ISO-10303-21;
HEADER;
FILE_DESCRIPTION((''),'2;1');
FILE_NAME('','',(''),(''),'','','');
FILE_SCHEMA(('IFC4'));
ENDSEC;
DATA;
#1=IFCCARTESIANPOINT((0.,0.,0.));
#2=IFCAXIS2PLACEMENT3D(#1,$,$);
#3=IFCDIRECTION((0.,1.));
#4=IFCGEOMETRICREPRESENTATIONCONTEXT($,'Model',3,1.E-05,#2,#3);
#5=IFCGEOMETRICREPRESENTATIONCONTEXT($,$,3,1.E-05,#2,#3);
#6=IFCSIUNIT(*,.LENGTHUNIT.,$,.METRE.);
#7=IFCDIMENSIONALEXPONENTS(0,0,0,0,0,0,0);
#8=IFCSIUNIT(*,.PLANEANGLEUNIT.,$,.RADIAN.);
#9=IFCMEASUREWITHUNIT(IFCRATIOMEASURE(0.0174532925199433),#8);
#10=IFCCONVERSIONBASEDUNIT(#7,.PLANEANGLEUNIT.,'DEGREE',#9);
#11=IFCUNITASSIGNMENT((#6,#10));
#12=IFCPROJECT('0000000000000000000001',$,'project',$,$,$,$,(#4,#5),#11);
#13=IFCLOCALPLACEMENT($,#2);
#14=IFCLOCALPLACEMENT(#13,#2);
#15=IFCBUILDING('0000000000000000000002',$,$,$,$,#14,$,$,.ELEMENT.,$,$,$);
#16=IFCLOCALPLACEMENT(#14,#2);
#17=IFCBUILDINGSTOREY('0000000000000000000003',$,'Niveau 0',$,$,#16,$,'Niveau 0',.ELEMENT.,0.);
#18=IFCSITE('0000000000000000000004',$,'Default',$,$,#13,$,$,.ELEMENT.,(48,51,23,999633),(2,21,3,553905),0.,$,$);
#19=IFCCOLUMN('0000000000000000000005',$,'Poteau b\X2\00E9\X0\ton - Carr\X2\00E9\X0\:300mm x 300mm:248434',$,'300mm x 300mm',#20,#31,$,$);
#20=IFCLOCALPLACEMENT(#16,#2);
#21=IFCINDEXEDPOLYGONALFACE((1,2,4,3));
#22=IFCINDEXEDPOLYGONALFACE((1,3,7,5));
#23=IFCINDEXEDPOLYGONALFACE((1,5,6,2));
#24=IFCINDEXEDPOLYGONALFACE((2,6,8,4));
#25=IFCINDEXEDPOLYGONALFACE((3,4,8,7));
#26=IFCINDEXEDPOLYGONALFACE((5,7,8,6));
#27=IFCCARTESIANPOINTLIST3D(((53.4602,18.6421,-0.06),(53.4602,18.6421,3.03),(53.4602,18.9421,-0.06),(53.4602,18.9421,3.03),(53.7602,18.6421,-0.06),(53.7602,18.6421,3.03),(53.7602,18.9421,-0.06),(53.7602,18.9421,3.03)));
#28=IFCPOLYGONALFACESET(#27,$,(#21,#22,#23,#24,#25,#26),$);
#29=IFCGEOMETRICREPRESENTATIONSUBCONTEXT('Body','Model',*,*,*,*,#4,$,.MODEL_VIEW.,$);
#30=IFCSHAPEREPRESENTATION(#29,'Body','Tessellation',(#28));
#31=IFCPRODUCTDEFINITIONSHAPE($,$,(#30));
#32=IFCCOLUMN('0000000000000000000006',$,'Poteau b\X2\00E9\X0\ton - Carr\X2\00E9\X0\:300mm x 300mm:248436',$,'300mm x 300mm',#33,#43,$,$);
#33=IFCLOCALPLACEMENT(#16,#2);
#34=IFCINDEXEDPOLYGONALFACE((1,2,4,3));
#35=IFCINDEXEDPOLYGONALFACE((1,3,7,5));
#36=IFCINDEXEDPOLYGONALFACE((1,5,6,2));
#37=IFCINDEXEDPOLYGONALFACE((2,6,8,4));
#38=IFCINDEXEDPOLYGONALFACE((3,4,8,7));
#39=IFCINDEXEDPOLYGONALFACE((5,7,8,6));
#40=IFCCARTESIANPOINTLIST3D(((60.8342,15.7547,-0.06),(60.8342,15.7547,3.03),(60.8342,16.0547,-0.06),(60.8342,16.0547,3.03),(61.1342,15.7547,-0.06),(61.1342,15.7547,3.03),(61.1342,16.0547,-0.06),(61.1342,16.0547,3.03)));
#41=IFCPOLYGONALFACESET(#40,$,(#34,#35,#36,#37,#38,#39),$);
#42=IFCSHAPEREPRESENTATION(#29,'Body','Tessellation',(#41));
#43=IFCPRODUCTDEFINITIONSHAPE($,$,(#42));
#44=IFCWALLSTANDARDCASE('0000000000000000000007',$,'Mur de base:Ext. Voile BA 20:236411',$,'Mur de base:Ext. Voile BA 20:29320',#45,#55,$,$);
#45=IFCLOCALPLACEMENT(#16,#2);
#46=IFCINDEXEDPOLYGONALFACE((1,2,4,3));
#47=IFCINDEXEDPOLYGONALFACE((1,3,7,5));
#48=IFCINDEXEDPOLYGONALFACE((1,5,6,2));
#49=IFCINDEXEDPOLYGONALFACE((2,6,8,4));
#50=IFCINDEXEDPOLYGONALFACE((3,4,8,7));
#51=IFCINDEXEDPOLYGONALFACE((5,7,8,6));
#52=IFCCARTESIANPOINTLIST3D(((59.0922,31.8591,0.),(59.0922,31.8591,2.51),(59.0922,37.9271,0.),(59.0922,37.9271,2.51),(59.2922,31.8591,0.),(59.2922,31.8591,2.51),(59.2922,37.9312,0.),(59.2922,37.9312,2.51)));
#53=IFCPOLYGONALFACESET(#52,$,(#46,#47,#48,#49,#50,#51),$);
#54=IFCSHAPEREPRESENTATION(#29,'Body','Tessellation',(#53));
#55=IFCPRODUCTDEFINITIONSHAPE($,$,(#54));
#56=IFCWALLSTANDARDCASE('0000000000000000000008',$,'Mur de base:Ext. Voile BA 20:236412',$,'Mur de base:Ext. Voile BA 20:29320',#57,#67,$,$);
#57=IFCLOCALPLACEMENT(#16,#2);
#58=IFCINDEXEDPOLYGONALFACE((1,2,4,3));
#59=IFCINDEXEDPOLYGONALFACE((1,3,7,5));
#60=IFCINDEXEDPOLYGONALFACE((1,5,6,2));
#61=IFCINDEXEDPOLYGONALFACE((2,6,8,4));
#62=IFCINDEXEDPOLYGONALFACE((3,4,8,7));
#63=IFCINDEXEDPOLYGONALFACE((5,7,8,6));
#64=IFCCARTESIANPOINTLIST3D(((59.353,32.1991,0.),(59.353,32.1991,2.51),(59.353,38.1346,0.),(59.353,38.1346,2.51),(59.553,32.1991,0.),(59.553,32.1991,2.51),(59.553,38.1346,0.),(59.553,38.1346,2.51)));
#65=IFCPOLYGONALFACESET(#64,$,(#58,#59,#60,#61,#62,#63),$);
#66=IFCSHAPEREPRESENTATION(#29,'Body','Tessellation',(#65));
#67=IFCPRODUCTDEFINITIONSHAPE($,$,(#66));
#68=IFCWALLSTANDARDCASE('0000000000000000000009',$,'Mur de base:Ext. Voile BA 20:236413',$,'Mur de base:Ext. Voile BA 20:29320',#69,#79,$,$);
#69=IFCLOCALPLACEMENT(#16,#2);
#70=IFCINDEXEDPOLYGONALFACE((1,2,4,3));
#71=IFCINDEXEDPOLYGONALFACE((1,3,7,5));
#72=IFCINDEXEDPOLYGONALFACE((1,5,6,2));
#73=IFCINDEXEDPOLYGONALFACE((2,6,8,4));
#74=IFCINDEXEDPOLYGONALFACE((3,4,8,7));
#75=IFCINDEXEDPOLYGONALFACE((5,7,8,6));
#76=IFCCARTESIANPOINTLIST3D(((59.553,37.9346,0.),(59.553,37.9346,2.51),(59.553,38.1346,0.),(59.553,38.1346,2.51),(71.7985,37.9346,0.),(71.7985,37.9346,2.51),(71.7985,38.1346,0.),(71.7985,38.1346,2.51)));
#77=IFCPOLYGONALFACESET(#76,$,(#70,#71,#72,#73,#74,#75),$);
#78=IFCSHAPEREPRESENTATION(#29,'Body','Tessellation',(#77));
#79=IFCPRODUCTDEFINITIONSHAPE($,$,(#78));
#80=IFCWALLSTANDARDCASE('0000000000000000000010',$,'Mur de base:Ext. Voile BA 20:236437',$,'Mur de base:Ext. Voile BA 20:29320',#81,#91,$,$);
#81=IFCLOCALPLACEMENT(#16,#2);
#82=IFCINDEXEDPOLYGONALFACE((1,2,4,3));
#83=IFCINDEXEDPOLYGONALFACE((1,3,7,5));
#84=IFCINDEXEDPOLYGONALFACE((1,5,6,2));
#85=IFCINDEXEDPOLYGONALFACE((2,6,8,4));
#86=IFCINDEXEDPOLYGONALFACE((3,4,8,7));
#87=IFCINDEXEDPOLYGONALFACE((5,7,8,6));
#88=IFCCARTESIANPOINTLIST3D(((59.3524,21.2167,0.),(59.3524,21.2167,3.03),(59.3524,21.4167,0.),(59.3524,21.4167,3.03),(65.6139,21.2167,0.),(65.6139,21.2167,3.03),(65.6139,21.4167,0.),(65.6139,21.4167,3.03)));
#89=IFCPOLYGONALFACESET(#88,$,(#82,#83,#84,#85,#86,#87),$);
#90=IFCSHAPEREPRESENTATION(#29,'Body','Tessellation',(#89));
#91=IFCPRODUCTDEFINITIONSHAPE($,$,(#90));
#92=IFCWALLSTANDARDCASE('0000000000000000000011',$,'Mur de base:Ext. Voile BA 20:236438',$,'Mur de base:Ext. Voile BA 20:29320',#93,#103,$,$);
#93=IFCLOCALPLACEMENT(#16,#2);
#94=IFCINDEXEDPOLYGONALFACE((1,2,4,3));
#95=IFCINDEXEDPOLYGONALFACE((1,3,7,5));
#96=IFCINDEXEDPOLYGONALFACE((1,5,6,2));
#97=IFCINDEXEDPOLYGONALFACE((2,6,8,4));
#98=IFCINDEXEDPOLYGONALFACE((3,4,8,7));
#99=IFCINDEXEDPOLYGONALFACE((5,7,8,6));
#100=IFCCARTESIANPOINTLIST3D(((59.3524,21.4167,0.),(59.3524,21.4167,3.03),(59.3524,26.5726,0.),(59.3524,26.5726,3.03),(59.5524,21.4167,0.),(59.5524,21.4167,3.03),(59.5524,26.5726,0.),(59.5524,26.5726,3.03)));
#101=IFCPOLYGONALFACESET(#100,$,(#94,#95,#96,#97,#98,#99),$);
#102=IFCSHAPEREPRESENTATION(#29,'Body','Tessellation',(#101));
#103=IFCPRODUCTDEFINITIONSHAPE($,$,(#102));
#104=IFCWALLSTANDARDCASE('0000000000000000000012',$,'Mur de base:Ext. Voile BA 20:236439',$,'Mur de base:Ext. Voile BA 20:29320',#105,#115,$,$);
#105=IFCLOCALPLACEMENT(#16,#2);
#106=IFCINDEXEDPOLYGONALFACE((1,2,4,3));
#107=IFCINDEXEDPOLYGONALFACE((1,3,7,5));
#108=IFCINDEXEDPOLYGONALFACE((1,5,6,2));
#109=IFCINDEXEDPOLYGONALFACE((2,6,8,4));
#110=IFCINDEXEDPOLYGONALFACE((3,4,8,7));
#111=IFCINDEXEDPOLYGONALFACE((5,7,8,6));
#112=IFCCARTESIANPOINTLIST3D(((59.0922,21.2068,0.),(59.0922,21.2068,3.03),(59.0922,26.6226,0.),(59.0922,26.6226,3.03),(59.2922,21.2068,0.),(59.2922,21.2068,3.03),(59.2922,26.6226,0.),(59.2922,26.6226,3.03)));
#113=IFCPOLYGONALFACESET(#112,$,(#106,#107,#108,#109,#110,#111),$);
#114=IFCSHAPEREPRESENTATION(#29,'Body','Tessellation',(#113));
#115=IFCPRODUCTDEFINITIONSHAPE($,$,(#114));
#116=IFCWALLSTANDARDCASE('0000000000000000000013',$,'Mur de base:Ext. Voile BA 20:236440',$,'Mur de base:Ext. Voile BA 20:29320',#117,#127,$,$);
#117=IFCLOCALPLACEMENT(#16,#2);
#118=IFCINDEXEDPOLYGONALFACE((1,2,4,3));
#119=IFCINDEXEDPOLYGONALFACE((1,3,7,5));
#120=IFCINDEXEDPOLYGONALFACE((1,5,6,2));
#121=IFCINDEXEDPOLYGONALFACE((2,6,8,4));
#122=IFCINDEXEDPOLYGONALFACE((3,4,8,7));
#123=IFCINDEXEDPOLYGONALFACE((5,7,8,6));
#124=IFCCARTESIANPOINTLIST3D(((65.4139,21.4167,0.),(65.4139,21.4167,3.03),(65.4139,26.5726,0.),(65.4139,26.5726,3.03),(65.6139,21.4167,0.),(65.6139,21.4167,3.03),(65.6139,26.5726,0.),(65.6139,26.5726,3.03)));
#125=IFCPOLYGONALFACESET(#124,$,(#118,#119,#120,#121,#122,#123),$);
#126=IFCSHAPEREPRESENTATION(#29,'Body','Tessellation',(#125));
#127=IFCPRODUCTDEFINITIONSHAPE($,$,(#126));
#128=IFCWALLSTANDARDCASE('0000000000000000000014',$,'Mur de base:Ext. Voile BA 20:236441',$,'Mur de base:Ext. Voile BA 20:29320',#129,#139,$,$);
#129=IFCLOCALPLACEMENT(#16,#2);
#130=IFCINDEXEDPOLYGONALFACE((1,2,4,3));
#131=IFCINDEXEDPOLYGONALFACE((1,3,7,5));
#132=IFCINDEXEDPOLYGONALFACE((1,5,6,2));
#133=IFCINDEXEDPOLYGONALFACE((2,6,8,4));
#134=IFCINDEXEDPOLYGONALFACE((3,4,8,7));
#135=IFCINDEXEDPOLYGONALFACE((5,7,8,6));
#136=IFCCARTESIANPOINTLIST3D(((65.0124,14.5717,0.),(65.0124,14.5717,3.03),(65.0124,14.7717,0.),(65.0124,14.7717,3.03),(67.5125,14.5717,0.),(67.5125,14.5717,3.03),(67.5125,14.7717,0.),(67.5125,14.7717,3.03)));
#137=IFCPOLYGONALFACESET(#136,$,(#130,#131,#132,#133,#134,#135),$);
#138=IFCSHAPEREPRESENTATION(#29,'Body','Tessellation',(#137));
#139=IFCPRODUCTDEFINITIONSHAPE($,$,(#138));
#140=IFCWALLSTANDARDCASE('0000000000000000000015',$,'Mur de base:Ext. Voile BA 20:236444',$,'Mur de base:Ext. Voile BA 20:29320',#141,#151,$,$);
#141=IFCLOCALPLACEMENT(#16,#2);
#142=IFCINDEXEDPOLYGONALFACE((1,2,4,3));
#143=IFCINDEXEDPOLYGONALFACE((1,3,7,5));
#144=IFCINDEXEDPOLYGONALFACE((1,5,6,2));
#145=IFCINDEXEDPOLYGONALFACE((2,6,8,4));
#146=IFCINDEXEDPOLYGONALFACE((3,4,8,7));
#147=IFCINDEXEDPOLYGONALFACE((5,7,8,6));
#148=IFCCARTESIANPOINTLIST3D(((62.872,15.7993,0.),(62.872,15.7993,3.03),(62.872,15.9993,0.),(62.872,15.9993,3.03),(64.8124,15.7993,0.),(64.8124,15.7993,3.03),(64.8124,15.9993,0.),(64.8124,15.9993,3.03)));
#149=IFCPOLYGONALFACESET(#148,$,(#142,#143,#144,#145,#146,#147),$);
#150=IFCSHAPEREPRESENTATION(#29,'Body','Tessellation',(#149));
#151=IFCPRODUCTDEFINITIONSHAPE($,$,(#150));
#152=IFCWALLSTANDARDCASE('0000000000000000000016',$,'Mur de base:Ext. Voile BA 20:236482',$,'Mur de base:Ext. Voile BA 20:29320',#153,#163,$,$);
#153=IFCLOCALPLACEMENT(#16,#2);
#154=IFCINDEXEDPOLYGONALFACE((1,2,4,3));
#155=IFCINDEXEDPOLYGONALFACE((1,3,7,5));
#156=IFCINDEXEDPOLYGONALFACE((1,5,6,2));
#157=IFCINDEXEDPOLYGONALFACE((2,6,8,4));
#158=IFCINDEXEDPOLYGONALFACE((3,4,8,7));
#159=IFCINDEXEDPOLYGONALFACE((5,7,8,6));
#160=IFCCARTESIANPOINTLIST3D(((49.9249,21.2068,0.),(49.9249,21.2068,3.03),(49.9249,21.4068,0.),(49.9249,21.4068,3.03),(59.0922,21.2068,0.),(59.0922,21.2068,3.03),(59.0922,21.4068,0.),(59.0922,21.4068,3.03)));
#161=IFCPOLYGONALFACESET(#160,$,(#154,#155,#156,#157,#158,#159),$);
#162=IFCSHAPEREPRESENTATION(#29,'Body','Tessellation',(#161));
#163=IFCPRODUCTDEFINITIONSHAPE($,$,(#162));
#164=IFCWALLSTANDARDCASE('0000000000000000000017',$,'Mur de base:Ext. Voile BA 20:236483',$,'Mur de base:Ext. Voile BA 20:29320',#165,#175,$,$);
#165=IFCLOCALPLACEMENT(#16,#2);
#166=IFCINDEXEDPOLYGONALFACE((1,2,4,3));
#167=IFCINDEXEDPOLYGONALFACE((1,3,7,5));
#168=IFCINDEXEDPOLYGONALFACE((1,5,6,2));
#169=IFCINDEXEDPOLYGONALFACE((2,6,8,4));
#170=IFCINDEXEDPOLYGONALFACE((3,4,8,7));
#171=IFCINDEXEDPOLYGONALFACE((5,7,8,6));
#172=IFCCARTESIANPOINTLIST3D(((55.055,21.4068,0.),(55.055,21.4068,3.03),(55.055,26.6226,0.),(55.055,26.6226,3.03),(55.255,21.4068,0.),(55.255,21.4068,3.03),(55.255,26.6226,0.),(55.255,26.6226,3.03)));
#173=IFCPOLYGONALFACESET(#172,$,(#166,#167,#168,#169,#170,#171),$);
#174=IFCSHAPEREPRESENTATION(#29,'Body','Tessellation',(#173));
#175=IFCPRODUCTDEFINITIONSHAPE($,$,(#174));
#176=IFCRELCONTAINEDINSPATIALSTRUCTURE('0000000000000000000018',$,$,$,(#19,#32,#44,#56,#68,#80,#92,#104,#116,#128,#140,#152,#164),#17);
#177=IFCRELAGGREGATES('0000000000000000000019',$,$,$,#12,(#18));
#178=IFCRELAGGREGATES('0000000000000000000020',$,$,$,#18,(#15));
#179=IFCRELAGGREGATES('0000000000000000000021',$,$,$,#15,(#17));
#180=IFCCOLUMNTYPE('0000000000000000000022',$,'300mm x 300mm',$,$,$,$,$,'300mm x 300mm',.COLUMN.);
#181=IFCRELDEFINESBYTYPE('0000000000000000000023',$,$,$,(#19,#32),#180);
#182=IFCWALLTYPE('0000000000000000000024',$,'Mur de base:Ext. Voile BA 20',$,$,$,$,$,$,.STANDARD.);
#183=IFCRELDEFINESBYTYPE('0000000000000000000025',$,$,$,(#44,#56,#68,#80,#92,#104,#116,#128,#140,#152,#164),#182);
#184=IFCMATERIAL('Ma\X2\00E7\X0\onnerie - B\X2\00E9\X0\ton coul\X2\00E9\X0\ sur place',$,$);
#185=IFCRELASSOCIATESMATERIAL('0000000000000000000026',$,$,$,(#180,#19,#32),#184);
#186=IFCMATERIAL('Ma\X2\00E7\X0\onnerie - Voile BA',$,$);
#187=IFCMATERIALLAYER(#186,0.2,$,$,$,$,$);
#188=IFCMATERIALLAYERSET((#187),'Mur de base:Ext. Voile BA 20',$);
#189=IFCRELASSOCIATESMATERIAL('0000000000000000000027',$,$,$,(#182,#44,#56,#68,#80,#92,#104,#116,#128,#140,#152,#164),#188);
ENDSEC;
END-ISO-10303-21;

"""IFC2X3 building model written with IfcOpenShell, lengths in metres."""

from ifc_helpers import new_model, entity, si_unit, converted_unit, direction, frame, frame_2d, origin, origin_2d_with_axis, place, context, subcontext, project, spatial, polyline, rectangle, outline, extrude, source, transform, mapped, material, layer, layer_set, layer_usage, type_object, type_shapes, element, save


model = new_model("IFC2X3")

# Units and contexts
model_context = context("Model", 3, precision=1e-05, world=origin(), true_north=direction((0.0, 1.0)))
context_of_model = context(None, 3, precision=1e-05, world=origin(), true_north=direction((0.0, 1.0)))
body_context = subcontext(model_context, "Body", "Model", "MODEL_VIEW")
ifc_project = project(units=[si_unit("LENGTHUNIT", "METRE"), converted_unit("PLANEANGLEUNIT", "DEGREE", entity("IfcRatioMeasure", 0.0174532925199433), si_unit("PLANEANGLEUNIT", "RADIAN"), dimensions=[0, 0, 0, 0, 0, 0, 0])], contexts=[model_context, context_of_model])

# Site, building, storey
site_placement = place(None, origin())
site = spatial("IfcSite", under=ifc_project, at=site_placement, Name="Default", CompositionType="ELEMENT", RefLatitude=(48, 51, 23, 999633), RefLongitude=(2, 21, 3, 553905), RefElevation=0.0)
building_placement = place(site_placement, origin())
building = spatial("IfcBuilding", under=site, at=building_placement, CompositionType="ELEMENT")
storey_placement = place(building_placement, origin())
storey = spatial("IfcBuildingStorey", under=building, at=storey_placement, Name="Niveau 0", LongName="Niveau 0", CompositionType="ELEMENT", Elevation=0.0)

# Columns
ifc_material_1 = material(Name="Maçonnerie - Béton coulé sur place")
column_type = type_object("IfcColumnType", Name="300mm x 300mm", ElementType="300mm x 300mm", PredefinedType="COLUMN", material=ifc_material_1)
shared_shape = source(origin(), body_context, "Body", "SweptSolid", [
    extrude(rectangle(XDim=0.3, YDim=0.3, at=origin_2d_with_axis()), frame((0.0, 0.0, -0.06), z_axis=(0.0, 0.0, 1.0), x_axis=(-1.0, 0.0, 0.0)), (0.0, 0.0, 1.0), 3.09),
])
type_shapes(column_type, [shared_shape])
for number, where, name in (
    (1, (53.6102, 18.7921, 0.0), "Poteau béton - Carré:300mm x 300mm:248434"),
    (2, (60.9842, 15.9047, 0.0), "Poteau béton - Carré:300mm x 300mm:248436"),
):
    element("IfcColumn", number, at=place(storey_placement, frame(where)), inside=storey, type_object=column_type, material=ifc_material_1, Name=name, ObjectType="300mm x 300mm", context=body_context, shape_type="MappedRepresentation", body=[
        mapped(shared_shape, transform((0.0, 0.0, 0.0), scale=1.0)),
    ])

# Walls
ifc_material_2 = material(Name="Maçonnerie - Voile BA")
ifc_layer = layer(ifc_material_2, 0.2)
ifc_layer_set = layer_set([ifc_layer], Name="Mur de base:Ext. Voile BA 20")
ifc_layer_usage_1 = layer_usage(ifc_layer_set, "AXIS2", "NEGATIVE", 0.1)
wall_type = type_object("IfcWallType", Name="Mur de base:Ext. Voile BA 20", PredefinedType="STANDARD", material=ifc_layer_set)
wall_1_placement = place(storey_placement, frame((59.1922, 37.9312, 0.0), z_axis=(0.0, 0.0, 1.0), x_axis=(0.0, -1.0, 0.0)))
element("IfcWallStandardCase", 3, at=wall_1_placement, inside=storey, type_object=wall_type, material=ifc_layer_usage_1, Name="Mur de base:Ext. Voile BA 20:236411", ObjectType="Mur de base:Ext. Voile BA 20:29320", context=body_context, shape_type="SweptSolid", body=[
    extrude(outline(polyline([(6.0721, -0.1), (6.0721, 0.1), (0.0, 0.1), (0.0042, -0.1), (6.0721, -0.1)])), origin(), (0.0, 0.0, 1.0), 2.51),
])
ifc_layer_usage_2 = layer_usage(ifc_layer_set, "AXIS2", "NEGATIVE", 0.1)
wall_2_placement = place(storey_placement, frame((59.453, 32.1991, 0.0), z_axis=(0.0, 0.0, 1.0), x_axis=(0.0, 1.0, 0.0)))
element("IfcWallStandardCase", 4, at=wall_2_placement, inside=storey, type_object=wall_type, material=ifc_layer_usage_2, Name="Mur de base:Ext. Voile BA 20:236412", ObjectType="Mur de base:Ext. Voile BA 20:29320", context=body_context, shape_type="SweptSolid", body=[
    extrude(rectangle(XDim=5.9355, YDim=0.2, at=frame_2d((2.9677, 0.0), x_axis=(-1.0, 0.0))), origin(), (0.0, 0.0, 1.0), 2.51),
])
ifc_layer_usage_3 = layer_usage(ifc_layer_set, "AXIS2", "NEGATIVE", 0.1)
wall_3_placement = place(storey_placement, frame((59.553, 38.0346, 0.0)))
element("IfcWallStandardCase", 5, at=wall_3_placement, inside=storey, type_object=wall_type, material=ifc_layer_usage_3, Name="Mur de base:Ext. Voile BA 20:236413", ObjectType="Mur de base:Ext. Voile BA 20:29320", context=body_context, shape_type="SweptSolid", body=[
    extrude(rectangle(XDim=12.2455, YDim=0.2, at=frame_2d((6.1227, 0.0), x_axis=(-1.0, 0.0))), origin(), (0.0, 0.0, 1.0), 2.51),
])
ifc_layer_usage_4 = layer_usage(ifc_layer_set, "AXIS2", "NEGATIVE", 0.1)
wall_4_placement = place(storey_placement, frame((65.6139, 21.3167, 0.0), z_axis=(0.0, 0.0, 1.0), x_axis=(-1.0, 0.0, 0.0)))
element("IfcWallStandardCase", 6, at=wall_4_placement, inside=storey, type_object=wall_type, material=ifc_layer_usage_4, Name="Mur de base:Ext. Voile BA 20:236437", ObjectType="Mur de base:Ext. Voile BA 20:29320", context=body_context, shape_type="SweptSolid", body=[
    extrude(rectangle(XDim=6.2615, YDim=0.2, at=frame_2d((3.1307, 0.0), x_axis=(-1.0, 0.0))), origin(), (0.0, 0.0, 1.0), 3.03),
])
ifc_layer_usage_5 = layer_usage(ifc_layer_set, "AXIS2", "NEGATIVE", 0.1)
wall_5_placement = place(storey_placement, frame((59.4524, 21.4167, 0.0), z_axis=(0.0, 0.0, 1.0), x_axis=(0.0, 1.0, 0.0)))
element("IfcWallStandardCase", 7, at=wall_5_placement, inside=storey, type_object=wall_type, material=ifc_layer_usage_5, Name="Mur de base:Ext. Voile BA 20:236438", ObjectType="Mur de base:Ext. Voile BA 20:29320", context=body_context, shape_type="SweptSolid", body=[
    extrude(rectangle(XDim=5.156, YDim=0.2, at=frame_2d((2.578, 0.0), x_axis=(-1.0, 0.0))), origin(), (0.0, 0.0, 1.0), 3.03),
])
ifc_layer_usage_6 = layer_usage(ifc_layer_set, "AXIS2", "NEGATIVE", 0.1)
wall_6_placement = place(storey_placement, frame((59.1922, 26.6226, 0.0), z_axis=(0.0, 0.0, 1.0), x_axis=(0.0, -1.0, 0.0)))
element("IfcWallStandardCase", 8, at=wall_6_placement, inside=storey, type_object=wall_type, material=ifc_layer_usage_6, Name="Mur de base:Ext. Voile BA 20:236439", ObjectType="Mur de base:Ext. Voile BA 20:29320", context=body_context, shape_type="SweptSolid", body=[
    extrude(rectangle(XDim=5.4158, YDim=0.2, at=frame_2d((2.7079, 0.0), x_axis=(-1.0, 0.0))), origin(), (0.0, 0.0, 1.0), 3.03),
])
ifc_layer_usage_7 = layer_usage(ifc_layer_set, "AXIS2", "NEGATIVE", 0.1)
wall_7_placement = place(storey_placement, frame((65.5139, 26.5726, 0.0), z_axis=(0.0, 0.0, 1.0), x_axis=(0.0, -1.0, 0.0)))
element("IfcWallStandardCase", 9, at=wall_7_placement, inside=storey, type_object=wall_type, material=ifc_layer_usage_7, Name="Mur de base:Ext. Voile BA 20:236440", ObjectType="Mur de base:Ext. Voile BA 20:29320", context=body_context, shape_type="SweptSolid", body=[
    extrude(rectangle(XDim=5.156, YDim=0.2, at=frame_2d((2.578, 0.0), x_axis=(-1.0, 0.0))), origin(), (0.0, 0.0, 1.0), 3.03),
])
ifc_layer_usage_8 = layer_usage(ifc_layer_set, "AXIS2", "NEGATIVE", 0.1)
wall_8_placement = place(storey_placement, frame((67.5125, 14.6717, 0.0), z_axis=(0.0, 0.0, 1.0), x_axis=(-1.0, 0.0, 0.0)))
element("IfcWallStandardCase", 10, at=wall_8_placement, inside=storey, type_object=wall_type, material=ifc_layer_usage_8, Name="Mur de base:Ext. Voile BA 20:236441", ObjectType="Mur de base:Ext. Voile BA 20:29320", context=body_context, shape_type="SweptSolid", body=[
    extrude(rectangle(XDim=2.5001, YDim=0.2, at=frame_2d((1.25, 0.0), x_axis=(-1.0, 0.0))), origin(), (0.0, 0.0, 1.0), 3.03),
])
ifc_layer_usage_9 = layer_usage(ifc_layer_set, "AXIS2", "NEGATIVE", 0.1)
wall_9_placement = place(storey_placement, frame((62.872, 15.8993, 0.0)))
element("IfcWallStandardCase", 11, at=wall_9_placement, inside=storey, type_object=wall_type, material=ifc_layer_usage_9, Name="Mur de base:Ext. Voile BA 20:236444", ObjectType="Mur de base:Ext. Voile BA 20:29320", context=body_context, shape_type="SweptSolid", body=[
    extrude(rectangle(XDim=1.9404, YDim=0.2, at=frame_2d((0.9702, 0.0), x_axis=(-1.0, 0.0))), origin(), (0.0, 0.0, 1.0), 3.03),
])
ifc_layer_usage_10 = layer_usage(ifc_layer_set, "AXIS2", "NEGATIVE", 0.1)
wall_10_placement = place(storey_placement, frame((49.9249, 21.3068, 0.0)))
element("IfcWallStandardCase", 12, at=wall_10_placement, inside=storey, type_object=wall_type, material=ifc_layer_usage_10, Name="Mur de base:Ext. Voile BA 20:236482", ObjectType="Mur de base:Ext. Voile BA 20:29320", context=body_context, shape_type="SweptSolid", body=[
    extrude(rectangle(XDim=9.1672, YDim=0.2, at=frame_2d((4.5836, 0.0), x_axis=(-1.0, 0.0))), origin(), (0.0, 0.0, 1.0), 3.03),
])
ifc_layer_usage_11 = layer_usage(ifc_layer_set, "AXIS2", "NEGATIVE", 0.1)
wall_11_placement = place(storey_placement, frame((55.155, 21.4068, 0.0), z_axis=(0.0, 0.0, 1.0), x_axis=(0.0, 1.0, 0.0)))
element("IfcWallStandardCase", 13, at=wall_11_placement, inside=storey, type_object=wall_type, material=ifc_layer_usage_11, Name="Mur de base:Ext. Voile BA 20:236483", ObjectType="Mur de base:Ext. Voile BA 20:29320", context=body_context, shape_type="SweptSolid", body=[
    extrude(rectangle(XDim=5.2158, YDim=0.2, at=frame_2d((2.6079, 0.0), x_axis=(-1.0, 0.0))), origin(), (0.0, 0.0, 1.0), 3.03),
])

save(model, "model.ifc")
